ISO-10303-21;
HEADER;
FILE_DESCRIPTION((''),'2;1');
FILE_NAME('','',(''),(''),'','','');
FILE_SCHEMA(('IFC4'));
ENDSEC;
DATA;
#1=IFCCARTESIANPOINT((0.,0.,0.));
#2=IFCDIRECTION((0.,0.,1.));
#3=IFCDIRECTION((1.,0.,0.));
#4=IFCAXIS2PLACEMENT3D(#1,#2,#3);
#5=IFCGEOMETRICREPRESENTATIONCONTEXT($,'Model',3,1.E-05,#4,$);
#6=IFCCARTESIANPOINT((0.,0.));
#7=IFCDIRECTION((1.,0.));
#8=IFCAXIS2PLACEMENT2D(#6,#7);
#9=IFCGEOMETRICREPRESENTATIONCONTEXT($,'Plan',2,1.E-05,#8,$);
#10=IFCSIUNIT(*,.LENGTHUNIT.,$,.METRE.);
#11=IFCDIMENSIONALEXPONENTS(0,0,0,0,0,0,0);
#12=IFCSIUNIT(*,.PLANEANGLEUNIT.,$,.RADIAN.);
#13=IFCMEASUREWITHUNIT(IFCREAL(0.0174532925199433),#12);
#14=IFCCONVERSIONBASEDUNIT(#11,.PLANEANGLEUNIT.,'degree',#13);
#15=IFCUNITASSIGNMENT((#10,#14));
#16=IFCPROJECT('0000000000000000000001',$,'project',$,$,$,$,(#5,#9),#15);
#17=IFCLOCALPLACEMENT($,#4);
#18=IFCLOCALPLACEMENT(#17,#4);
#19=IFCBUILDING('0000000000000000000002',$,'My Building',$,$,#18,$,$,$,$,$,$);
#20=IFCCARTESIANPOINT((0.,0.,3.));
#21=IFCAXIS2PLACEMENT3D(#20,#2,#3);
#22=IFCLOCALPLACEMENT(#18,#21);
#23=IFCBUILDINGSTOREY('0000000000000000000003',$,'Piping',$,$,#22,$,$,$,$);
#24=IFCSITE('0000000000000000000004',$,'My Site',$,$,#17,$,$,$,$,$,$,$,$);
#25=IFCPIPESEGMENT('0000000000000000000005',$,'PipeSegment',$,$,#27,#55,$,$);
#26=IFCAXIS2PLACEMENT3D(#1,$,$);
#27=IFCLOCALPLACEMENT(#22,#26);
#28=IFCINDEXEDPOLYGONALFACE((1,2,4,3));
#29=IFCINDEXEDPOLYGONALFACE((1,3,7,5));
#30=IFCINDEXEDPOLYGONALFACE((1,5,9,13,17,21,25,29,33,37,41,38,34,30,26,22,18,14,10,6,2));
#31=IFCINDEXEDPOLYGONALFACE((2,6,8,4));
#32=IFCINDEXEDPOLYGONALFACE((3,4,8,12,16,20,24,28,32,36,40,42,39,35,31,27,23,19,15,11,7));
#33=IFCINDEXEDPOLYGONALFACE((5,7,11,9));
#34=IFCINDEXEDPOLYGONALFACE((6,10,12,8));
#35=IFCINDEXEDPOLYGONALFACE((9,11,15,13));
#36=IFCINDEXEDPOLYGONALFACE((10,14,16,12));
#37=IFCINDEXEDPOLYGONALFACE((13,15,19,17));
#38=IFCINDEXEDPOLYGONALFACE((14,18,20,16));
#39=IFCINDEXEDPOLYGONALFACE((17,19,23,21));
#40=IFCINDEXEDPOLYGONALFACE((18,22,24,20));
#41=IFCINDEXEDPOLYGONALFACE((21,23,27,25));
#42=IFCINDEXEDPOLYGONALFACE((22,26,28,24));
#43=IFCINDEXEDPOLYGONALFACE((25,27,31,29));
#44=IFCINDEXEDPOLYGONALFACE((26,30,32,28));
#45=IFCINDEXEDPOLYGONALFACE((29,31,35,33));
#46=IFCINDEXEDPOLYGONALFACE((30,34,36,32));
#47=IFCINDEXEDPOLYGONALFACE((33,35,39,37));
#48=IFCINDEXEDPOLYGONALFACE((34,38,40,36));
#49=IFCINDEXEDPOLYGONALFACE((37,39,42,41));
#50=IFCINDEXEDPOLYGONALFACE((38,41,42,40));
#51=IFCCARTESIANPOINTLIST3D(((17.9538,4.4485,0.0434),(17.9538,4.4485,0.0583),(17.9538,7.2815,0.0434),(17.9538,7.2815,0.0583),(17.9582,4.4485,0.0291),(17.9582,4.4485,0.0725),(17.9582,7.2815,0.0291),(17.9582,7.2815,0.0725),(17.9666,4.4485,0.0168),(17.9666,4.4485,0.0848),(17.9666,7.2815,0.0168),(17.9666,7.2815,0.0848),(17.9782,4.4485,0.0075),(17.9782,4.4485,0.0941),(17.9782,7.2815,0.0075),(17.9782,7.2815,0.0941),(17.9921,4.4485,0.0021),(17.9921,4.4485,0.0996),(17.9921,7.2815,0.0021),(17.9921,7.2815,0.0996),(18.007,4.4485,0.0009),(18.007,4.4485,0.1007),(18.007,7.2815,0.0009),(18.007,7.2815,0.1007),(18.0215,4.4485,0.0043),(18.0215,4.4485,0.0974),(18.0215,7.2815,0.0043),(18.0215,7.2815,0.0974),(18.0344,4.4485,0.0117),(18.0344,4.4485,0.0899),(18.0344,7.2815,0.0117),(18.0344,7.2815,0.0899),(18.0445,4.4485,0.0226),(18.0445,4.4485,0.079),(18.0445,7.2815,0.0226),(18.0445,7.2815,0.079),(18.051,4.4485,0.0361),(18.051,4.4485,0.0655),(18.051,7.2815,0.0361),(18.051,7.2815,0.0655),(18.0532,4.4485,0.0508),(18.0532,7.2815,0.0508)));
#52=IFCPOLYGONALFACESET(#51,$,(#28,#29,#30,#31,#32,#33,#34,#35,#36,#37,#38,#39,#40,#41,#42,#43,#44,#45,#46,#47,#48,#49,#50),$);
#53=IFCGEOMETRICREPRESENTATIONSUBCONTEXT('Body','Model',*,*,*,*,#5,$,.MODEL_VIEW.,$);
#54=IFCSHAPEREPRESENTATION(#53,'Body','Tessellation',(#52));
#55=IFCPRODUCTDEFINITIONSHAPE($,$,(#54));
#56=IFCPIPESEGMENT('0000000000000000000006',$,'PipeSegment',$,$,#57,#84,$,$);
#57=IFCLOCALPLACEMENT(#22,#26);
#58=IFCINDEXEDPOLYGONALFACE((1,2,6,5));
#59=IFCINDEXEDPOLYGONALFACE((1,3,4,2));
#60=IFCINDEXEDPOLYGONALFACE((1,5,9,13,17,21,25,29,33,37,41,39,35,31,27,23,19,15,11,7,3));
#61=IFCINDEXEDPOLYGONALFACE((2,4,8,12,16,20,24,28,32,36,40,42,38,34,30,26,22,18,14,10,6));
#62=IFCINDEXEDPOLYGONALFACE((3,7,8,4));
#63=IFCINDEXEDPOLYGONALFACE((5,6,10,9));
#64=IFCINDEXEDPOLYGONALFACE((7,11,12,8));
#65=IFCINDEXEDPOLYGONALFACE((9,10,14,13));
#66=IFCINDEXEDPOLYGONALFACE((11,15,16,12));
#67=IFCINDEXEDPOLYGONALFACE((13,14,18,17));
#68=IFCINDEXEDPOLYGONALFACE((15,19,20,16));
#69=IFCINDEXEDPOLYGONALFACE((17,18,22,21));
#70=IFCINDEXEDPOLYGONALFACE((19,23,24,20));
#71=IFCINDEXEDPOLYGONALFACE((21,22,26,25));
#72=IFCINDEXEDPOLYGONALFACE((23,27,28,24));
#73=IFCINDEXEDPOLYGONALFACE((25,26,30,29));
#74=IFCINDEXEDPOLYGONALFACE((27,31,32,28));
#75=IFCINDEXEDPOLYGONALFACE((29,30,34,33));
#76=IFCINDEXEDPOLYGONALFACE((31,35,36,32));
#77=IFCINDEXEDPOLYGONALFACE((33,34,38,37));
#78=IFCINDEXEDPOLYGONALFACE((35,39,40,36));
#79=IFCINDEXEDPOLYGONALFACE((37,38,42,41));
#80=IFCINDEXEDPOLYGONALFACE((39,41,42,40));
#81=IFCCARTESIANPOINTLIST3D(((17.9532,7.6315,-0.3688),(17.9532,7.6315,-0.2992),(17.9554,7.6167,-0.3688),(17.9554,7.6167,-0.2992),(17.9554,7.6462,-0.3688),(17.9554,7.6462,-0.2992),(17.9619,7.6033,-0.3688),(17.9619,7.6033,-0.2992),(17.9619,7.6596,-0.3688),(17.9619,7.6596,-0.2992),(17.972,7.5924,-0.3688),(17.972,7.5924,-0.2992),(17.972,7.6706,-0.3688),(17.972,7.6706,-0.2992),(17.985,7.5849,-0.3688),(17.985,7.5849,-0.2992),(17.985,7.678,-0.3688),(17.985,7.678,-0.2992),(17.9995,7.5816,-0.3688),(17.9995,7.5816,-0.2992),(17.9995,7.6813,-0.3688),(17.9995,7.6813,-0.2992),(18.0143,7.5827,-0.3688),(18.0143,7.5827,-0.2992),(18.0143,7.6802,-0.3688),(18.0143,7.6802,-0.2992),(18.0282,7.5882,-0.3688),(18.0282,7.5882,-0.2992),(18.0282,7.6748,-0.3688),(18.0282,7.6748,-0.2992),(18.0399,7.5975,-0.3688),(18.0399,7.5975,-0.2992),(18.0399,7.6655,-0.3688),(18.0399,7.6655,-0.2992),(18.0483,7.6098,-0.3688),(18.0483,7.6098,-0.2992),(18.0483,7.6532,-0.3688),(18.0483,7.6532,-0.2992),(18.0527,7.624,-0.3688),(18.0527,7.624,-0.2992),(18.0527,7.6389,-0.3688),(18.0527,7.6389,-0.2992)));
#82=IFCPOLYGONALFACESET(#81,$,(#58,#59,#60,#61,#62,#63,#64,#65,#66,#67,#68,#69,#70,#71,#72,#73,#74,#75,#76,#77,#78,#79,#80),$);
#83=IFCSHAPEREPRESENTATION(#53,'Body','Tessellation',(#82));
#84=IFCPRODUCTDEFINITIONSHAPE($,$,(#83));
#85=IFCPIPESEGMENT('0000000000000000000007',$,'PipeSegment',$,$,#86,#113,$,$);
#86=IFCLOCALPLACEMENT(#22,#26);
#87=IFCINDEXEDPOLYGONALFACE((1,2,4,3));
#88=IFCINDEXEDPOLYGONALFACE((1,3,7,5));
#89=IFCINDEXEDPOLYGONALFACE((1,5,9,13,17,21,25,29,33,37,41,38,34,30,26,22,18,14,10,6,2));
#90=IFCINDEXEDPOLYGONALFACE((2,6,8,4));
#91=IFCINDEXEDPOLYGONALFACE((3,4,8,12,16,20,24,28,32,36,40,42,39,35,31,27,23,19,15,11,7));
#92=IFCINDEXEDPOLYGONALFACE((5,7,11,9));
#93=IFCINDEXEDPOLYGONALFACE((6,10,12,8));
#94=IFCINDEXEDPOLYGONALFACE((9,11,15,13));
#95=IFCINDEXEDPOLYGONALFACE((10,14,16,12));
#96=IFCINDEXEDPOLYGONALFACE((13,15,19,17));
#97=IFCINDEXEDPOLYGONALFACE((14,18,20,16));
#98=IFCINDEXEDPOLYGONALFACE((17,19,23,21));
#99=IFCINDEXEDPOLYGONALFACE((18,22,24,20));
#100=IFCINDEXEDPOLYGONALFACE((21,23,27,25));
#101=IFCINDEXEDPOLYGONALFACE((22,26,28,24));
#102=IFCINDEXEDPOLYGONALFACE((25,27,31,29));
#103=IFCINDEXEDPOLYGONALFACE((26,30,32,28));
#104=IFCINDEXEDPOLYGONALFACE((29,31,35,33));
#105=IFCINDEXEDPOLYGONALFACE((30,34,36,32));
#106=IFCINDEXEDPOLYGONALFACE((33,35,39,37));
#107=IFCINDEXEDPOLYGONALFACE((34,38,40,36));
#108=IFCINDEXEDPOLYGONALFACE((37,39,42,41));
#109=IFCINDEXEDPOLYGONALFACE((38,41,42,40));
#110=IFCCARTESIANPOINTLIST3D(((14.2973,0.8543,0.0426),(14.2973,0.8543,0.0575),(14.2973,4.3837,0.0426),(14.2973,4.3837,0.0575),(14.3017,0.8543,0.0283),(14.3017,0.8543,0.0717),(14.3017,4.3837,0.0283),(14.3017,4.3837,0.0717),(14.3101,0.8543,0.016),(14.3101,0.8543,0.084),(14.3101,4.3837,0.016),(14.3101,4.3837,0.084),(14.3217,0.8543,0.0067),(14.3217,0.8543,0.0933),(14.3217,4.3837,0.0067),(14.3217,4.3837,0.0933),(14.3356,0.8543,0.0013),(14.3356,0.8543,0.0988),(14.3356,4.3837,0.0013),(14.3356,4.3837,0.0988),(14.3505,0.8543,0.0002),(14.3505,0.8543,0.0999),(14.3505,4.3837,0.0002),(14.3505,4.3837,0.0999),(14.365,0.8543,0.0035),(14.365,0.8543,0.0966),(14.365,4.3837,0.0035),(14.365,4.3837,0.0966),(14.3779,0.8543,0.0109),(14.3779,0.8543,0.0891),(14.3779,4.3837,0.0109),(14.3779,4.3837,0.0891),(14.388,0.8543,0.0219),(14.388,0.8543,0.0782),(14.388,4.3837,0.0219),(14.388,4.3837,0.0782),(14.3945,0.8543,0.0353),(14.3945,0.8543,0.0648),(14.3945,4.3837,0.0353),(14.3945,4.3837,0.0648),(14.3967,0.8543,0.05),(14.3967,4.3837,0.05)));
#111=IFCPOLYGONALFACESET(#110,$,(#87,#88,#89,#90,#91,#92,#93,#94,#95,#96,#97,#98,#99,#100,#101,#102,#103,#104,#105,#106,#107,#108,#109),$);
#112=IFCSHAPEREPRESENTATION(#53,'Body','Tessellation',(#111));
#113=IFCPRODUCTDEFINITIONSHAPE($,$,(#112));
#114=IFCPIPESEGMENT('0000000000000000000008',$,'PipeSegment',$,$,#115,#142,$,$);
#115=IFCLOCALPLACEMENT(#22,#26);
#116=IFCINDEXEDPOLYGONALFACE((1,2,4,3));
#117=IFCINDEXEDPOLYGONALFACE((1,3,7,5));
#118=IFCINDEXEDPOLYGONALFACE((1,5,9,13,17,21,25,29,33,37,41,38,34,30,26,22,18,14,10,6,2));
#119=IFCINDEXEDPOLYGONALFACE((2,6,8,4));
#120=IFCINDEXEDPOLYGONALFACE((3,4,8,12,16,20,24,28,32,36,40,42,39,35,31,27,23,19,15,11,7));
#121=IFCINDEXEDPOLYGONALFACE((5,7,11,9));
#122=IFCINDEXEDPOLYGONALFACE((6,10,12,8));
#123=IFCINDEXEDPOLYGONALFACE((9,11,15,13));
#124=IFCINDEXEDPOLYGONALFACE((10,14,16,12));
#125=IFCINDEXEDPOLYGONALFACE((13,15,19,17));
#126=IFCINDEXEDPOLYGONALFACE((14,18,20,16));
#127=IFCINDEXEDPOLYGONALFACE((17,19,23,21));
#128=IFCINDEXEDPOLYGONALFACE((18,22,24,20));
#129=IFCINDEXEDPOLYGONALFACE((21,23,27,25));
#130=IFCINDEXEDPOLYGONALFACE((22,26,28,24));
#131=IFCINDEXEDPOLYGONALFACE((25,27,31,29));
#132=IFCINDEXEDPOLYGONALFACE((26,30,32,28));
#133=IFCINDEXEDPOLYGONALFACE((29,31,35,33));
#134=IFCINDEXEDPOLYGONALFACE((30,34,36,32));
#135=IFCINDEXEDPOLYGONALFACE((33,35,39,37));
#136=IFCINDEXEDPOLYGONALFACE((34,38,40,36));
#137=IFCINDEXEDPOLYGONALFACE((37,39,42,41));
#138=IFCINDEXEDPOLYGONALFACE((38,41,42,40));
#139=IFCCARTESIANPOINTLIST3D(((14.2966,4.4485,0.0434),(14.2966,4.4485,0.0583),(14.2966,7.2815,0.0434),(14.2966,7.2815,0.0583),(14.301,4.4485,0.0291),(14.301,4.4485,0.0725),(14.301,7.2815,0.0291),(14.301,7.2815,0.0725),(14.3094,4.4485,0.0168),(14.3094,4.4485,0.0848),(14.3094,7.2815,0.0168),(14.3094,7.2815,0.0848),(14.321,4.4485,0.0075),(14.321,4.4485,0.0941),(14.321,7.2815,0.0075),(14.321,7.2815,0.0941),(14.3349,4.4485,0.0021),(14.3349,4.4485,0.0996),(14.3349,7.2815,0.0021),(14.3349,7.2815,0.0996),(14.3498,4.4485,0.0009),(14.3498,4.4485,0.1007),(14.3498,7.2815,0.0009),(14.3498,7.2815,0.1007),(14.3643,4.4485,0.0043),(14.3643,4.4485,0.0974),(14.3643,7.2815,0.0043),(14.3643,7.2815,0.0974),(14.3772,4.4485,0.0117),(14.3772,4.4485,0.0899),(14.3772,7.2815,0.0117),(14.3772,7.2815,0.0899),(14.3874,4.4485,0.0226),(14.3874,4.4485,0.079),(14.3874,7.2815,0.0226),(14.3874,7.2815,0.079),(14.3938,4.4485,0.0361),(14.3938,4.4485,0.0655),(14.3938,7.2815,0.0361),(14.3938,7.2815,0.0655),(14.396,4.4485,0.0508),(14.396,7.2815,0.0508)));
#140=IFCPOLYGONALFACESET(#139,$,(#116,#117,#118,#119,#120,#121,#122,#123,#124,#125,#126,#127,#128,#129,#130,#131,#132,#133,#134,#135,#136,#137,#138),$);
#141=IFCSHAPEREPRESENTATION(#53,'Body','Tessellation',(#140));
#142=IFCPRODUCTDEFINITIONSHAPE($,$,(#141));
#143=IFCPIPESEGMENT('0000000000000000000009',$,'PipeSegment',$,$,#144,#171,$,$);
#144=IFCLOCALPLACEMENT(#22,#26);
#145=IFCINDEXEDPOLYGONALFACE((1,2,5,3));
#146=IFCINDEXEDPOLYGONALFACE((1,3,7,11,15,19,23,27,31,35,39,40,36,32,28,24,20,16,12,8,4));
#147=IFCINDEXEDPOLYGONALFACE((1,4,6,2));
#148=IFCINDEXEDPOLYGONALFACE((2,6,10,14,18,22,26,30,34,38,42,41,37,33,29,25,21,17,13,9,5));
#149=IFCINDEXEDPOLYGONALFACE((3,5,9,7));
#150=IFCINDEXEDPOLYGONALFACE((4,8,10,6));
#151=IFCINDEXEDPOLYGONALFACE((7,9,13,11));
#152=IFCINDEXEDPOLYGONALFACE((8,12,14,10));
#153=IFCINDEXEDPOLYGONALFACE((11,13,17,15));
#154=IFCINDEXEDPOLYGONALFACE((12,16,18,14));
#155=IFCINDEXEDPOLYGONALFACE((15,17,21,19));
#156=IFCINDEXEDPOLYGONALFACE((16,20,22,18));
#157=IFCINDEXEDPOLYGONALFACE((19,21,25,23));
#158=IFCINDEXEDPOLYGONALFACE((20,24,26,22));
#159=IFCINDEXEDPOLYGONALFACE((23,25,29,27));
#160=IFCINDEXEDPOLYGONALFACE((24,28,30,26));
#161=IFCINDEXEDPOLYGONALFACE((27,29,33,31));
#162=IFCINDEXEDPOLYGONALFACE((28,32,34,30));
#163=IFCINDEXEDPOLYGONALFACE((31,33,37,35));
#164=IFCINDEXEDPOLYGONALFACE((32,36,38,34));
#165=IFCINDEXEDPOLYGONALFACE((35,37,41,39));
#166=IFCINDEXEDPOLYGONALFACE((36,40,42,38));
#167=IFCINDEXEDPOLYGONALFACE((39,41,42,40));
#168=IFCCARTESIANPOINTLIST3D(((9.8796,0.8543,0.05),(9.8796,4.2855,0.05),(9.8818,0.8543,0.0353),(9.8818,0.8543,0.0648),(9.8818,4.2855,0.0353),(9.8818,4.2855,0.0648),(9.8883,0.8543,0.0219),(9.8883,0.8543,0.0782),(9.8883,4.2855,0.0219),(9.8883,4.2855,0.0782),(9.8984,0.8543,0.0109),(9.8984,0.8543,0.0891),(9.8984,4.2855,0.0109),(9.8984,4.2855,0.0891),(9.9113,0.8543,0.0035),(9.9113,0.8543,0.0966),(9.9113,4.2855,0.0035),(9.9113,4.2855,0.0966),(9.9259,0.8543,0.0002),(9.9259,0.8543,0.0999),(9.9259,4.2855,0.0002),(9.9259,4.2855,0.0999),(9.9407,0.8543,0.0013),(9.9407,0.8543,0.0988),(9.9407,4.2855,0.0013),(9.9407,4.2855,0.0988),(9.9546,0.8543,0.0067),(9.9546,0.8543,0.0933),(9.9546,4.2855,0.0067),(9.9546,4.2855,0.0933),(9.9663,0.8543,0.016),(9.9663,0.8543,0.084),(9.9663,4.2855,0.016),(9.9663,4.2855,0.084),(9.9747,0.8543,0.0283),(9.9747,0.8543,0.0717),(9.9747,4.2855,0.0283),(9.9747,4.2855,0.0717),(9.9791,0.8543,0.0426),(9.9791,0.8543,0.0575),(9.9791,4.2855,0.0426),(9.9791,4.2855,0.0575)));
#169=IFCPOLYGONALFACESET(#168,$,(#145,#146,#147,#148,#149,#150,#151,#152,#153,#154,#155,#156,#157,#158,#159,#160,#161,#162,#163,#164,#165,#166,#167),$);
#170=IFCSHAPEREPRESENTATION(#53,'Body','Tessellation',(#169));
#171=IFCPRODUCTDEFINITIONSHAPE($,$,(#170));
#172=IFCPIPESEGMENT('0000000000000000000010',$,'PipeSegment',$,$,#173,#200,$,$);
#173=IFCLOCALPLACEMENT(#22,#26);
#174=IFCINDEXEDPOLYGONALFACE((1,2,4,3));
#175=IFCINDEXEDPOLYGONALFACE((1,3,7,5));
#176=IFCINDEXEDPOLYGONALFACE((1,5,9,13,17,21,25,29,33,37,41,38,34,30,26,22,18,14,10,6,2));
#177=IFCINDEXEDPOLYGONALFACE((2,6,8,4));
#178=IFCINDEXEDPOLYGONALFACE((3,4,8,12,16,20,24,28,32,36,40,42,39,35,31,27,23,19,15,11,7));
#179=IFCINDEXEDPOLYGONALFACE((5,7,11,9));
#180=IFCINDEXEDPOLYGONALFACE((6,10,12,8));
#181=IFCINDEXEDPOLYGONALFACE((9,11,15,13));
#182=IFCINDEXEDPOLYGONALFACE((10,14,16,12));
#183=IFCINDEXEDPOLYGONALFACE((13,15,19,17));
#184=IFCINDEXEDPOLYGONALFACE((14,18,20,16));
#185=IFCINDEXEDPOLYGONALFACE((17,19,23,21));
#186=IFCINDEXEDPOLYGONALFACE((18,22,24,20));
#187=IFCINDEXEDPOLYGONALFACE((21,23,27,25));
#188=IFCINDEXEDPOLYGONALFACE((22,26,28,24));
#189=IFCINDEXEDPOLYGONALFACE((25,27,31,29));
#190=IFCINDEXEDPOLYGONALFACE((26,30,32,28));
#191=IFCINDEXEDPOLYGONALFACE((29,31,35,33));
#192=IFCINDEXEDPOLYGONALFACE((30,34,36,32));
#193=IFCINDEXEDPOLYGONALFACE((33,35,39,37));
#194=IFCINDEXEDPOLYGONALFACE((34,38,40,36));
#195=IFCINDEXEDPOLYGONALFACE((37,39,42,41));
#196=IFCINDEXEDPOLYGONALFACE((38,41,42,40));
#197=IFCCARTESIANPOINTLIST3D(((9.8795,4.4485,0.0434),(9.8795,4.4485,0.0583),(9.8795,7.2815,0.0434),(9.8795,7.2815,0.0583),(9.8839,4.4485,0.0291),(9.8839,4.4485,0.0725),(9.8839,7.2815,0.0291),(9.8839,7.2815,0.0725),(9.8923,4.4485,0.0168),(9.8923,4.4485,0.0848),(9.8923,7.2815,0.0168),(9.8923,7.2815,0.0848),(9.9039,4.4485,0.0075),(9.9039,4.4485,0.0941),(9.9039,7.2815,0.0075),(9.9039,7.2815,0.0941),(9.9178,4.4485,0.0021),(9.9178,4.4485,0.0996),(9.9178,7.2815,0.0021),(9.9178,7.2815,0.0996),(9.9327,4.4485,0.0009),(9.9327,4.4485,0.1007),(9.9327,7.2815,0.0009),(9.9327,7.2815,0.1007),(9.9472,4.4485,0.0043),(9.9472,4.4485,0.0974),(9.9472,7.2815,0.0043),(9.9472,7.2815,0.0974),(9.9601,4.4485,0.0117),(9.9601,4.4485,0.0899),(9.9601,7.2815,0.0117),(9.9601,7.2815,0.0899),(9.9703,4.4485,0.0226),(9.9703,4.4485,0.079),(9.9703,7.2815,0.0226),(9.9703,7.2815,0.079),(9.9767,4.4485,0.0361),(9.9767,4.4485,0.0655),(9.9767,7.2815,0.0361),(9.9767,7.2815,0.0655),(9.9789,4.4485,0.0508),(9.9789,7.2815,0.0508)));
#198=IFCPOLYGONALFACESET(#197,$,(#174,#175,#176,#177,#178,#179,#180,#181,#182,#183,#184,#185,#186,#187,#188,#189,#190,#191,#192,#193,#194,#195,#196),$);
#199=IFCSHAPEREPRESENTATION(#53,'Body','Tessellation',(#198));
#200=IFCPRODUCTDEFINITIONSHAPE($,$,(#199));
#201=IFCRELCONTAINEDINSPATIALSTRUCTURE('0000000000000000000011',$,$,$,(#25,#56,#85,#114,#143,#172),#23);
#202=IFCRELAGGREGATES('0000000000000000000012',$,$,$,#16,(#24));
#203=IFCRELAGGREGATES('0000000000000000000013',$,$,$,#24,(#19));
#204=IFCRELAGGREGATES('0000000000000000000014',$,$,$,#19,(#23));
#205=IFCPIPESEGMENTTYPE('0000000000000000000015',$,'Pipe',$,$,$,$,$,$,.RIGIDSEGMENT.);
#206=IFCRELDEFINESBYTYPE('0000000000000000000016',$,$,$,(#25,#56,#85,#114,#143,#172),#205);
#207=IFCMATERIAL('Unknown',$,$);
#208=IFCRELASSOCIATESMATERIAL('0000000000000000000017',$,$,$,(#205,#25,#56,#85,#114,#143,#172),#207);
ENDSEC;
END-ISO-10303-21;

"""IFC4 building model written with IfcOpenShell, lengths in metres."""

from ifc_helpers import new_model, entity, si_unit, converted_unit, frame, origin_with_axes, origin_2d_with_axis, place, context, subcontext, project, spatial, circle, extrude, material, material_profile, profile_set, profile_usage, type_object, element, save


model = new_model("IFC4")

# Units and contexts
model_context = context("Model", 3, precision=1e-05, world=origin_with_axes())
plan_context = context("Plan", 2, precision=1e-05, world=origin_2d_with_axis())
body_context = subcontext(model_context, "Body", "Model", "MODEL_VIEW")
ifc_project = project(units=[si_unit("LENGTHUNIT", "METRE"), converted_unit("PLANEANGLEUNIT", "degree", entity("IfcReal", 0.0174532925199433), si_unit("PLANEANGLEUNIT", "RADIAN"), dimensions=[0, 0, 0, 0, 0, 0, 0])], contexts=[model_context, plan_context])

# Site, building, storey
site_placement = place(None, origin_with_axes())
site = spatial("IfcSite", under=ifc_project, at=site_placement, Name="My Site")
building_placement = place(site_placement, origin_with_axes())
building = spatial("IfcBuilding", under=site, at=building_placement, Name="My Building")
storey_placement = place(building_placement, frame((0.0, 0.0, 3.0), z_axis=(0.0, 0.0, 1.0), x_axis=(1.0, 0.0, 0.0)))
storey = spatial("IfcBuildingStorey", under=building, at=storey_placement, Name="Piping")

# Pipe segments
ifc_material = material(Name="Unknown")
ifc_material_profile_1 = material_profile(ifc_material, circle(Radius=0.05))
ifc_profile_set_1 = profile_set([ifc_material_profile_1])
pipe_segment_type = type_object("IfcPipeSegmentType", Name="Pipe", PredefinedType="RIGIDSEGMENT", material=ifc_profile_set_1)
ifc_profile_usage_1 = profile_usage(ifc_profile_set_1, cardinal=5)
pipe_segment_1_placement = place(storey_placement, frame((18.0032, 4.4485, 0.0508), z_axis=(0.0, 1.0, 0.0), x_axis=(1.0, 0.0, 0.0)))
element("IfcPipeSegment", 1, at=pipe_segment_1_placement, inside=storey, type_object=pipe_segment_type, material=ifc_profile_usage_1, Name="PipeSegment", context=body_context, shape_type="SweptSolid", body=[
    extrude(circle(Radius=0.05), origin_with_axes(), (0.0, 0.0, 1.0), 2.833),
])
ifc_profile_usage_2 = profile_usage(ifc_profile_set_1, cardinal=16)
pipe_segment_2_placement = place(storey_placement, frame((18.0032, 7.6315, -0.2992), z_axis=(0.0, 0.0, -1.0), x_axis=(-1.0, 0.0, 0.0)))
element("IfcPipeSegment", 2, at=pipe_segment_2_placement, inside=storey, type_object=pipe_segment_type, material=ifc_profile_usage_2, Name="PipeSegment", context=body_context, shape_type="SweptSolid", body=[
    extrude(circle(Radius=0.05), origin_with_axes(), (0.0, 0.0, 1.0), 0.0696),
])
ifc_profile_usage_3 = profile_usage(ifc_profile_set_1, cardinal=5)
pipe_segment_3_placement = place(storey_placement, frame((14.3467, 4.3837, 0.05), z_axis=(0.0, -1.0, 0.0), x_axis=(1.0, 0.0, 0.0)))
element("IfcPipeSegment", 3, at=pipe_segment_3_placement, inside=storey, type_object=pipe_segment_type, material=ifc_profile_usage_3, Name="PipeSegment", context=body_context, shape_type="SweptSolid", body=[
    extrude(circle(Radius=0.05), origin_with_axes(), (0.0, 0.0, 1.0), 3.5295),
])
ifc_profile_usage_4 = profile_usage(ifc_profile_set_1, cardinal=5)
pipe_segment_4_placement = place(storey_placement, frame((14.346, 4.4485, 0.0508), z_axis=(0.0, 1.0, 0.0), x_axis=(1.0, 0.0, 0.0)))
element("IfcPipeSegment", 4, at=pipe_segment_4_placement, inside=storey, type_object=pipe_segment_type, material=ifc_profile_usage_4, Name="PipeSegment", context=body_context, shape_type="SweptSolid", body=[
    extrude(circle(Radius=0.05), origin_with_axes(), (0.0, 0.0, 1.0), 2.833),
])
ifc_profile_usage_5 = profile_usage(ifc_profile_set_1, cardinal=5)
pipe_segment_5_placement = place(storey_placement, frame((9.9296, 0.8543, 0.05), z_axis=(0.0, 1.0, 0.0), x_axis=(-1.0, 0.0, 0.0)))
element("IfcPipeSegment", 5, at=pipe_segment_5_placement, inside=storey, type_object=pipe_segment_type, material=ifc_profile_usage_5, Name="PipeSegment", context=body_context, shape_type="SweptSolid", body=[
    extrude(circle(Radius=0.05), origin_with_axes(), (0.0, 0.0, 1.0), 3.4313),
])
ifc_profile_usage_6 = profile_usage(ifc_profile_set_1, cardinal=5)
pipe_segment_6_placement = place(storey_placement, frame((9.9289, 4.4485, 0.0508), z_axis=(0.0, 1.0, 0.0), x_axis=(1.0, 0.0, 0.0)))
element("IfcPipeSegment", 6, at=pipe_segment_6_placement, inside=storey, type_object=pipe_segment_type, material=ifc_profile_usage_6, Name="PipeSegment", context=body_context, shape_type="SweptSolid", body=[
    extrude(circle(Radius=0.05), origin_with_axes(), (0.0, 0.0, 1.0), 2.833),
])

save(model, "model.ifc")
